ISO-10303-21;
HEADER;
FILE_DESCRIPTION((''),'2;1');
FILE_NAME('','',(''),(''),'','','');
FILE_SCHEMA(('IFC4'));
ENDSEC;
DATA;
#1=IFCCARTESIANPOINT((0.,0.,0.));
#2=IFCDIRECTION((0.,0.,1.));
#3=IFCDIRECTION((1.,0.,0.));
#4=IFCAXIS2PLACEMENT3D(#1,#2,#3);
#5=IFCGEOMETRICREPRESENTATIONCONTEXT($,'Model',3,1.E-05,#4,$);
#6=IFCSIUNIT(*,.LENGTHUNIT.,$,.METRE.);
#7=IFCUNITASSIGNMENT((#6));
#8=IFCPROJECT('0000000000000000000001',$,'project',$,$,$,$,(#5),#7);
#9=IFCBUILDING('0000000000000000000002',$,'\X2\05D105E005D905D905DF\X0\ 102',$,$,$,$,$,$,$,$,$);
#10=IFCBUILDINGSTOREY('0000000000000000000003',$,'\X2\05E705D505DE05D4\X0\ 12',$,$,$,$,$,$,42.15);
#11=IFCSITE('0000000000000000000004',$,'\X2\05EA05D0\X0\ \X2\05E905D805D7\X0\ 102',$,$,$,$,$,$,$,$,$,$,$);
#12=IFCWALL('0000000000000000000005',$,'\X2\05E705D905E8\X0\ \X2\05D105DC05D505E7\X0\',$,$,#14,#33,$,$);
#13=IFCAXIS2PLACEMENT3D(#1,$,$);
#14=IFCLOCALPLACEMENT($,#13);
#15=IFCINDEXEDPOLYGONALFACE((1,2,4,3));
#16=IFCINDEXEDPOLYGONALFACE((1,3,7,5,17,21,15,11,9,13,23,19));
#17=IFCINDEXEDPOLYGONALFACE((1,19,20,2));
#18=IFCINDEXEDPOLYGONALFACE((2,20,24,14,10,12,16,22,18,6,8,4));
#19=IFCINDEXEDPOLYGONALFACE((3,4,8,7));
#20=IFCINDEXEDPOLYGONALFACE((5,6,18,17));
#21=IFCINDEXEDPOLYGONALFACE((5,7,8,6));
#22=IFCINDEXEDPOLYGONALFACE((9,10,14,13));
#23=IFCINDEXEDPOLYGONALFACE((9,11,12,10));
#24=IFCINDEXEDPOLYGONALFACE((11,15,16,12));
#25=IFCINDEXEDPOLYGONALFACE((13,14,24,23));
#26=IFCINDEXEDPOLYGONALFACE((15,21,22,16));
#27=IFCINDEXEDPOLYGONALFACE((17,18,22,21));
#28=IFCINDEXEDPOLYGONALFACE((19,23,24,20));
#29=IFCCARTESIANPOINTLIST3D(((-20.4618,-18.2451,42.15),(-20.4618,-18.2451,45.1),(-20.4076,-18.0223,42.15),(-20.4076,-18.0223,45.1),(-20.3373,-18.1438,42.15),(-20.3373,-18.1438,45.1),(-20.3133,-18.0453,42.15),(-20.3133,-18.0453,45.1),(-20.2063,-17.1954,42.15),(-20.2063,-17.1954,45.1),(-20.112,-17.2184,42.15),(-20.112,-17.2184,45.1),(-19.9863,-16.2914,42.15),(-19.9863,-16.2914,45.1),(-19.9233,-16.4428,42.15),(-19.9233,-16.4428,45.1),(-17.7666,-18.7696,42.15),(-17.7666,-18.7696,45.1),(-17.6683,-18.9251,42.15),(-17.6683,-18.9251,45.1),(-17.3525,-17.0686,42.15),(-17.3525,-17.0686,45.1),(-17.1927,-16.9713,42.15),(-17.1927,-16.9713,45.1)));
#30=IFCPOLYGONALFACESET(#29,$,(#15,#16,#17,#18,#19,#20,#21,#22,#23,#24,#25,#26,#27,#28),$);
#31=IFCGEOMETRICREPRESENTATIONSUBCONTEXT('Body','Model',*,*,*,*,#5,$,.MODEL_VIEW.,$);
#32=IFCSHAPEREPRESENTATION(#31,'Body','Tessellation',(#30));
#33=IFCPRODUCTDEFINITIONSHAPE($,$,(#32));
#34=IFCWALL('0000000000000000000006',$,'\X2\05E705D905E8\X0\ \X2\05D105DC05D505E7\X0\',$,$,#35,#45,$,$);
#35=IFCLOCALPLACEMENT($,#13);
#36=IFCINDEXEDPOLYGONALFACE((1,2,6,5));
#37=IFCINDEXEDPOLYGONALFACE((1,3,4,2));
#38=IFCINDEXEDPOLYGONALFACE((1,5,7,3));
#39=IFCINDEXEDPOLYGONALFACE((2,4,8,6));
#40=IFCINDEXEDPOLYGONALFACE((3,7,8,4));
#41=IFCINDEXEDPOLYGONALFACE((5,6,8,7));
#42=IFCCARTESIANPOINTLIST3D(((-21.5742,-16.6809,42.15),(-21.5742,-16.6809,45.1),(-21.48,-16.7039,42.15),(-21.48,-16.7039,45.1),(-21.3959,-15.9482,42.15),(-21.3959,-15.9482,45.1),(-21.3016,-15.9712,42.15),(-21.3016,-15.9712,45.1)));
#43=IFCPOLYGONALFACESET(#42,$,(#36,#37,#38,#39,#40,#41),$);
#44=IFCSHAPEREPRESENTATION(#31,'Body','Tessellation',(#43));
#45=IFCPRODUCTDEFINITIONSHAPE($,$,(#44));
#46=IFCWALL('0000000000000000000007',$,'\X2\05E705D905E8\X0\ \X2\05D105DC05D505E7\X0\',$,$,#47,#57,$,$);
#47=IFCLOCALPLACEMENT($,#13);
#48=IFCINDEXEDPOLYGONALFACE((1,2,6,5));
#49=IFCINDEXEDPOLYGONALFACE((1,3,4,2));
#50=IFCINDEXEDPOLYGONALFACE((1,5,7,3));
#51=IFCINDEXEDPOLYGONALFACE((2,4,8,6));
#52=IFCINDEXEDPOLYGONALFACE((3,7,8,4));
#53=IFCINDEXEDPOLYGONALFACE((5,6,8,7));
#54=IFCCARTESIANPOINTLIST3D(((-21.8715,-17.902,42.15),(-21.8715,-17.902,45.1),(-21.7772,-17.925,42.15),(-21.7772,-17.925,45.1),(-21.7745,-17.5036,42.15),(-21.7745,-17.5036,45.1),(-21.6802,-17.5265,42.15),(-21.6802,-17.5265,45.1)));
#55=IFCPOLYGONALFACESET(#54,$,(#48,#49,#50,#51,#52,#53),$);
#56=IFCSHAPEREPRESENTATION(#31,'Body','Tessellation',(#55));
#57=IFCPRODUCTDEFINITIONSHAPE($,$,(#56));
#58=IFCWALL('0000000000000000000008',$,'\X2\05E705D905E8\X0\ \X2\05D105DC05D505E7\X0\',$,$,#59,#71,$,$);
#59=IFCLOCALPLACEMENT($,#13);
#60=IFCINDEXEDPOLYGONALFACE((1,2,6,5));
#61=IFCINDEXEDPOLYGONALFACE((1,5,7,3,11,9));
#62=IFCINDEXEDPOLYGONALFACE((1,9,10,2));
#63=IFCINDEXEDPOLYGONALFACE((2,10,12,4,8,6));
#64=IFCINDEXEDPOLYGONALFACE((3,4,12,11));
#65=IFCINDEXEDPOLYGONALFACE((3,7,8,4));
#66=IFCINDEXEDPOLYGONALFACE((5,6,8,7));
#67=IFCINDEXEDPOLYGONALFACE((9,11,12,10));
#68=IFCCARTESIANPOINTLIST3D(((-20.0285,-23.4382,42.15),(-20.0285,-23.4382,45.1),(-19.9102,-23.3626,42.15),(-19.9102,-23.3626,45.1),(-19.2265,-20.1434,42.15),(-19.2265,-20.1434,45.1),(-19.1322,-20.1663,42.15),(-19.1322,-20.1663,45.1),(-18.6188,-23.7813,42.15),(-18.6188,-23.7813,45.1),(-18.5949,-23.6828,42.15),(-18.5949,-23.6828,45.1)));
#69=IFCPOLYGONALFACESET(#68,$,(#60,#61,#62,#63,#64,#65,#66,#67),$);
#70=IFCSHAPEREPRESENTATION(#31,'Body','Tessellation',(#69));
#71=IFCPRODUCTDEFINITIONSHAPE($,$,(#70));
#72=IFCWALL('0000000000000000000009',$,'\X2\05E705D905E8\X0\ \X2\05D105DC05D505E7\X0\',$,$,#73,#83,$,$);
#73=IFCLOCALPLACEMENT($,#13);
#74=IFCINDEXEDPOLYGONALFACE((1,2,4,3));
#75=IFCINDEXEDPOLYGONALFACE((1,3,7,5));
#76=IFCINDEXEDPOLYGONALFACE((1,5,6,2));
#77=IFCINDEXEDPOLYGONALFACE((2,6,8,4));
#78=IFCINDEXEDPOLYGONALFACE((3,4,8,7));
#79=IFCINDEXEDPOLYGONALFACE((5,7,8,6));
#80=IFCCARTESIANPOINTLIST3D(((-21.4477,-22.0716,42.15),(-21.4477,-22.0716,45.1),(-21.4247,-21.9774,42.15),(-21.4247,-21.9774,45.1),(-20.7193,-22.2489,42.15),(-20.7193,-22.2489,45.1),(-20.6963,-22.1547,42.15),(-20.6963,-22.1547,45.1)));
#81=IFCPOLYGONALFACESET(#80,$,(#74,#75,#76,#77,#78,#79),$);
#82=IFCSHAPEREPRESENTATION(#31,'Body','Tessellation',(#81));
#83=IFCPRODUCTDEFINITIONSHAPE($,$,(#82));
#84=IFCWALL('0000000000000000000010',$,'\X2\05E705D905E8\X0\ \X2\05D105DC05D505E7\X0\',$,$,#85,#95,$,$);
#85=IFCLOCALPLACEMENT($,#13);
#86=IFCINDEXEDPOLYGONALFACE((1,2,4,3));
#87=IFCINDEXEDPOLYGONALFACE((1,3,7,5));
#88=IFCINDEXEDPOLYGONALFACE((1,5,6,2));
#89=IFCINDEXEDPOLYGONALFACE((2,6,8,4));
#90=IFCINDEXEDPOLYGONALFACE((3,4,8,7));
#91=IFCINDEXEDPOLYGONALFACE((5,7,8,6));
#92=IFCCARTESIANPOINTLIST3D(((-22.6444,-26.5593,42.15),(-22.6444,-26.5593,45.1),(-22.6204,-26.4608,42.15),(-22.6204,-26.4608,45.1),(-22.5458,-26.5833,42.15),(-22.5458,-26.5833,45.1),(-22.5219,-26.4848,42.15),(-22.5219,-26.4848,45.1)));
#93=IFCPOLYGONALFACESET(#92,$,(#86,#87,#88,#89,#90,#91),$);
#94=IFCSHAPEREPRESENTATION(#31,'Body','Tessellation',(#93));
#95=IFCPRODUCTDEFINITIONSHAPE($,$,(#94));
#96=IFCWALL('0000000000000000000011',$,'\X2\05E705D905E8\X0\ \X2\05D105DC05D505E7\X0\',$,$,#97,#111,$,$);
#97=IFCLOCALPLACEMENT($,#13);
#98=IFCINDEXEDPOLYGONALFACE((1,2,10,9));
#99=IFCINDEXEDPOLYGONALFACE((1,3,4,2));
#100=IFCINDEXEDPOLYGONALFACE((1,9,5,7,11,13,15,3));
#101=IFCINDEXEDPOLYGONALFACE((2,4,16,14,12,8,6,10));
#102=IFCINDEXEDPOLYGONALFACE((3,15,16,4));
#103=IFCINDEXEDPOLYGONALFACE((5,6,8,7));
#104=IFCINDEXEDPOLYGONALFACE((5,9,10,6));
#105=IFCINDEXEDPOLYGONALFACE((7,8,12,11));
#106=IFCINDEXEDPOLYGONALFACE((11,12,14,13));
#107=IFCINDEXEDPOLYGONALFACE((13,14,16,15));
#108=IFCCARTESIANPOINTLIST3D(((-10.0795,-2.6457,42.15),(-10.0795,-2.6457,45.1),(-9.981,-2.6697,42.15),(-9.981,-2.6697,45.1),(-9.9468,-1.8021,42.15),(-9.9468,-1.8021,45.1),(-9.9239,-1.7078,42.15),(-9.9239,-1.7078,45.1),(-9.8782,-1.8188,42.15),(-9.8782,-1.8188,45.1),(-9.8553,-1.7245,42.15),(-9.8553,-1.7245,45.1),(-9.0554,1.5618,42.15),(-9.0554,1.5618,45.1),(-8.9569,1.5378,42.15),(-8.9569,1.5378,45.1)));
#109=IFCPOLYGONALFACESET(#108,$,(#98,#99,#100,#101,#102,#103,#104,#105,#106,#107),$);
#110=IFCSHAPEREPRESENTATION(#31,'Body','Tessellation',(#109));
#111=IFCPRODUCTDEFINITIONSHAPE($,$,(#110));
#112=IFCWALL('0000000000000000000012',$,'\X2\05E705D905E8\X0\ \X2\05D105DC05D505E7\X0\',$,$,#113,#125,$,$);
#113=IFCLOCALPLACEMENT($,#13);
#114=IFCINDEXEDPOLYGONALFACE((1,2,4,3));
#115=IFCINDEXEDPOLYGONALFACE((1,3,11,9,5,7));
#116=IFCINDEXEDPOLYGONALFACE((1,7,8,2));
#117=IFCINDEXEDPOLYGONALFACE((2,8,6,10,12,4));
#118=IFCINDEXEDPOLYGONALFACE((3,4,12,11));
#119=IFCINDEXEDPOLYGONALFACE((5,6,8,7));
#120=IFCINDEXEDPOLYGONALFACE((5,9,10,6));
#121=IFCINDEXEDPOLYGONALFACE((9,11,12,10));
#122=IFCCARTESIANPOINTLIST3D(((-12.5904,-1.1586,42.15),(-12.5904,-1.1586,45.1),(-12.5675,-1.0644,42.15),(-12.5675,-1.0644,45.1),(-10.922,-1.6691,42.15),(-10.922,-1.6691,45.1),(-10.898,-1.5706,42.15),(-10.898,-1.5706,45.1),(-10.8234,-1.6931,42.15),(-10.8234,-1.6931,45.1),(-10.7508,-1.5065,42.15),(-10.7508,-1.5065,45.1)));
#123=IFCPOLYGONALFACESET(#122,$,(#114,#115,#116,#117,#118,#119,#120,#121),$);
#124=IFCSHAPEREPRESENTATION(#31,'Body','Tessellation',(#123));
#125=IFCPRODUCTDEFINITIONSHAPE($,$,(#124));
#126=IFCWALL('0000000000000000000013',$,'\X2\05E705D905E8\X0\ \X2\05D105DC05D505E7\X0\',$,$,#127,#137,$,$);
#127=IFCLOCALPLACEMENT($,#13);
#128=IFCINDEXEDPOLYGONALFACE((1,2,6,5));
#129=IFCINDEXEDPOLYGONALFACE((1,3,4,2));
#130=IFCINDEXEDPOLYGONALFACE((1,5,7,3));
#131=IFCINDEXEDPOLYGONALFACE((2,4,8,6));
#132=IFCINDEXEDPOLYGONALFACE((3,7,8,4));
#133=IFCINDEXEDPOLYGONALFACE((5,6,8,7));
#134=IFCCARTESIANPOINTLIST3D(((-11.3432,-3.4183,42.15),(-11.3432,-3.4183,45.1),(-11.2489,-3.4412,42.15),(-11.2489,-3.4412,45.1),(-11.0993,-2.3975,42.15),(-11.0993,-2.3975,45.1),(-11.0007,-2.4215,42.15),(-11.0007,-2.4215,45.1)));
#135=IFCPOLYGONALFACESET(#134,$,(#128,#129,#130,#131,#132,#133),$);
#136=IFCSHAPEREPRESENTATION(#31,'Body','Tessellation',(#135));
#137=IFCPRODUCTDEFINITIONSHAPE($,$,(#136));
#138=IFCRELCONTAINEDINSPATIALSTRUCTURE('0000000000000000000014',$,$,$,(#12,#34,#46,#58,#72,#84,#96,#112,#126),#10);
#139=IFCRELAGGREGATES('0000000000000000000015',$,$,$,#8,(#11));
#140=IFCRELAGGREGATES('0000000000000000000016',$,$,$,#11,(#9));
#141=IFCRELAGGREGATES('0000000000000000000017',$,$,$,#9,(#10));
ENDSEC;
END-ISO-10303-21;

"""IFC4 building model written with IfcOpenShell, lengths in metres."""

from ifc_helpers import new_model, si_unit, frame, origin_with_axes, context, subcontext, project, spatial, polyline, outline, extrude, element, save


model = new_model("IFC4")

# Units and contexts
model_context = context("Model", 3, precision=1e-05, world=origin_with_axes())
body_context = subcontext(model_context, "Body", "Model", "MODEL_VIEW")
ifc_project = project(units=[si_unit("LENGTHUNIT", "METRE")], contexts=[model_context])

# Site, building, storey
site = spatial("IfcSite", under=ifc_project, Name="תא שטח 102")
building = spatial("IfcBuilding", under=site, Name="בניין 102")
storey = spatial("IfcBuildingStorey", under=building, Name="קומה 12", Elevation=42.15)

# Walls
element("IfcWall", 1, inside=storey, Name="קיר בלוק", context=body_context, shape_type="SweptSolid", body=[
    extrude(outline(polyline([(-19.9233, -16.4428), (-17.3525, -17.0686), (-17.7666, -18.7696), (-20.3373, -18.1438), (-20.3133, -18.0453), (-20.4076, -18.0223), (-20.4618, -18.2451), (-17.6683, -18.9251), (-17.1927, -16.9713), (-19.9863, -16.2914), (-20.2063, -17.1954), (-20.112, -17.2184), (-19.9233, -16.4428)])), frame((0.0, 0.0, 42.15)), (0.0, 0.0, 1.0), 2.95),
])
element("IfcWall", 2, inside=storey, Name="קיר בלוק", context=body_context, shape_type="SweptSolid", body=[
    extrude(outline(polyline([(-21.3959, -15.9482), (-21.5742, -16.6809), (-21.48, -16.7039), (-21.3016, -15.9712), (-21.3959, -15.9482)])), frame((0.0, 0.0, 42.15)), (0.0, 0.0, 1.0), 2.95),
])
element("IfcWall", 3, inside=storey, Name="קיר בלוק", context=body_context, shape_type="SweptSolid", body=[
    extrude(outline(polyline([(-21.8715, -17.902), (-21.7772, -17.925), (-21.6802, -17.5265), (-21.7745, -17.5036), (-21.8715, -17.902)])), frame((0.0, 0.0, 42.15)), (0.0, 0.0, 1.0), 2.95),
])
element("IfcWall", 4, inside=storey, Name="קיר בלוק", context=body_context, shape_type="SweptSolid", body=[
    extrude(outline(polyline([(-18.5949, -23.6828), (-19.9102, -23.3626), (-19.1322, -20.1663), (-19.2265, -20.1434), (-20.0285, -23.4382), (-18.6188, -23.7813), (-18.5949, -23.6828)])), frame((0.0, 0.0, 42.15)), (0.0, 0.0, 1.0), 2.95),
])
element("IfcWall", 5, inside=storey, Name="קיר בלוק", context=body_context, shape_type="SweptSolid", body=[
    extrude(outline(polyline([(-21.4477, -22.0716), (-20.7193, -22.2489), (-20.6963, -22.1547), (-21.4247, -21.9774), (-21.4477, -22.0716)])), frame((0.0, 0.0, 42.15)), (0.0, 0.0, 1.0), 2.95),
])
element("IfcWall", 6, inside=storey, Name="קיר בלוק", context=body_context, shape_type="SweptSolid", body=[
    extrude(outline(polyline([(-22.6444, -26.5593), (-22.5458, -26.5833), (-22.5219, -26.4848), (-22.6204, -26.4608), (-22.6444, -26.5593)])), frame((0.0, 0.0, 42.15)), (0.0, 0.0, 1.0), 2.95),
])
element("IfcWall", 7, inside=storey, Name="קיר בלוק", context=body_context, shape_type="SweptSolid", body=[
    extrude(outline(polyline([(-10.0795, -2.6457), (-9.981, -2.6697), (-8.9569, 1.5378), (-9.0554, 1.5618), (-9.8553, -1.7245), (-9.9239, -1.7078), (-9.9468, -1.8021), (-9.8782, -1.8188), (-10.0795, -2.6457)])), frame((0.0, 0.0, 42.15)), (0.0, 0.0, 1.0), 2.95),
])
element("IfcWall", 8, inside=storey, Name="קיר בלוק", context=body_context, shape_type="SweptSolid", body=[
    extrude(outline(polyline([(-10.922, -1.6691), (-10.8234, -1.6931), (-10.7508, -1.5065), (-12.5675, -1.0644), (-12.5904, -1.1586), (-10.898, -1.5706), (-10.922, -1.6691)])), frame((0.0, 0.0, 42.15)), (0.0, 0.0, 1.0), 2.95),
])
element("IfcWall", 9, inside=storey, Name="קיר בלוק", context=body_context, shape_type="SweptSolid", body=[
    extrude(outline(polyline([(-11.2489, -3.4412), (-11.0007, -2.4215), (-11.0993, -2.3975), (-11.3432, -3.4183), (-11.2489, -3.4412)])), frame((0.0, 0.0, 42.15)), (0.0, 0.0, 1.0), 2.95),
])

save(model, "model.ifc")
